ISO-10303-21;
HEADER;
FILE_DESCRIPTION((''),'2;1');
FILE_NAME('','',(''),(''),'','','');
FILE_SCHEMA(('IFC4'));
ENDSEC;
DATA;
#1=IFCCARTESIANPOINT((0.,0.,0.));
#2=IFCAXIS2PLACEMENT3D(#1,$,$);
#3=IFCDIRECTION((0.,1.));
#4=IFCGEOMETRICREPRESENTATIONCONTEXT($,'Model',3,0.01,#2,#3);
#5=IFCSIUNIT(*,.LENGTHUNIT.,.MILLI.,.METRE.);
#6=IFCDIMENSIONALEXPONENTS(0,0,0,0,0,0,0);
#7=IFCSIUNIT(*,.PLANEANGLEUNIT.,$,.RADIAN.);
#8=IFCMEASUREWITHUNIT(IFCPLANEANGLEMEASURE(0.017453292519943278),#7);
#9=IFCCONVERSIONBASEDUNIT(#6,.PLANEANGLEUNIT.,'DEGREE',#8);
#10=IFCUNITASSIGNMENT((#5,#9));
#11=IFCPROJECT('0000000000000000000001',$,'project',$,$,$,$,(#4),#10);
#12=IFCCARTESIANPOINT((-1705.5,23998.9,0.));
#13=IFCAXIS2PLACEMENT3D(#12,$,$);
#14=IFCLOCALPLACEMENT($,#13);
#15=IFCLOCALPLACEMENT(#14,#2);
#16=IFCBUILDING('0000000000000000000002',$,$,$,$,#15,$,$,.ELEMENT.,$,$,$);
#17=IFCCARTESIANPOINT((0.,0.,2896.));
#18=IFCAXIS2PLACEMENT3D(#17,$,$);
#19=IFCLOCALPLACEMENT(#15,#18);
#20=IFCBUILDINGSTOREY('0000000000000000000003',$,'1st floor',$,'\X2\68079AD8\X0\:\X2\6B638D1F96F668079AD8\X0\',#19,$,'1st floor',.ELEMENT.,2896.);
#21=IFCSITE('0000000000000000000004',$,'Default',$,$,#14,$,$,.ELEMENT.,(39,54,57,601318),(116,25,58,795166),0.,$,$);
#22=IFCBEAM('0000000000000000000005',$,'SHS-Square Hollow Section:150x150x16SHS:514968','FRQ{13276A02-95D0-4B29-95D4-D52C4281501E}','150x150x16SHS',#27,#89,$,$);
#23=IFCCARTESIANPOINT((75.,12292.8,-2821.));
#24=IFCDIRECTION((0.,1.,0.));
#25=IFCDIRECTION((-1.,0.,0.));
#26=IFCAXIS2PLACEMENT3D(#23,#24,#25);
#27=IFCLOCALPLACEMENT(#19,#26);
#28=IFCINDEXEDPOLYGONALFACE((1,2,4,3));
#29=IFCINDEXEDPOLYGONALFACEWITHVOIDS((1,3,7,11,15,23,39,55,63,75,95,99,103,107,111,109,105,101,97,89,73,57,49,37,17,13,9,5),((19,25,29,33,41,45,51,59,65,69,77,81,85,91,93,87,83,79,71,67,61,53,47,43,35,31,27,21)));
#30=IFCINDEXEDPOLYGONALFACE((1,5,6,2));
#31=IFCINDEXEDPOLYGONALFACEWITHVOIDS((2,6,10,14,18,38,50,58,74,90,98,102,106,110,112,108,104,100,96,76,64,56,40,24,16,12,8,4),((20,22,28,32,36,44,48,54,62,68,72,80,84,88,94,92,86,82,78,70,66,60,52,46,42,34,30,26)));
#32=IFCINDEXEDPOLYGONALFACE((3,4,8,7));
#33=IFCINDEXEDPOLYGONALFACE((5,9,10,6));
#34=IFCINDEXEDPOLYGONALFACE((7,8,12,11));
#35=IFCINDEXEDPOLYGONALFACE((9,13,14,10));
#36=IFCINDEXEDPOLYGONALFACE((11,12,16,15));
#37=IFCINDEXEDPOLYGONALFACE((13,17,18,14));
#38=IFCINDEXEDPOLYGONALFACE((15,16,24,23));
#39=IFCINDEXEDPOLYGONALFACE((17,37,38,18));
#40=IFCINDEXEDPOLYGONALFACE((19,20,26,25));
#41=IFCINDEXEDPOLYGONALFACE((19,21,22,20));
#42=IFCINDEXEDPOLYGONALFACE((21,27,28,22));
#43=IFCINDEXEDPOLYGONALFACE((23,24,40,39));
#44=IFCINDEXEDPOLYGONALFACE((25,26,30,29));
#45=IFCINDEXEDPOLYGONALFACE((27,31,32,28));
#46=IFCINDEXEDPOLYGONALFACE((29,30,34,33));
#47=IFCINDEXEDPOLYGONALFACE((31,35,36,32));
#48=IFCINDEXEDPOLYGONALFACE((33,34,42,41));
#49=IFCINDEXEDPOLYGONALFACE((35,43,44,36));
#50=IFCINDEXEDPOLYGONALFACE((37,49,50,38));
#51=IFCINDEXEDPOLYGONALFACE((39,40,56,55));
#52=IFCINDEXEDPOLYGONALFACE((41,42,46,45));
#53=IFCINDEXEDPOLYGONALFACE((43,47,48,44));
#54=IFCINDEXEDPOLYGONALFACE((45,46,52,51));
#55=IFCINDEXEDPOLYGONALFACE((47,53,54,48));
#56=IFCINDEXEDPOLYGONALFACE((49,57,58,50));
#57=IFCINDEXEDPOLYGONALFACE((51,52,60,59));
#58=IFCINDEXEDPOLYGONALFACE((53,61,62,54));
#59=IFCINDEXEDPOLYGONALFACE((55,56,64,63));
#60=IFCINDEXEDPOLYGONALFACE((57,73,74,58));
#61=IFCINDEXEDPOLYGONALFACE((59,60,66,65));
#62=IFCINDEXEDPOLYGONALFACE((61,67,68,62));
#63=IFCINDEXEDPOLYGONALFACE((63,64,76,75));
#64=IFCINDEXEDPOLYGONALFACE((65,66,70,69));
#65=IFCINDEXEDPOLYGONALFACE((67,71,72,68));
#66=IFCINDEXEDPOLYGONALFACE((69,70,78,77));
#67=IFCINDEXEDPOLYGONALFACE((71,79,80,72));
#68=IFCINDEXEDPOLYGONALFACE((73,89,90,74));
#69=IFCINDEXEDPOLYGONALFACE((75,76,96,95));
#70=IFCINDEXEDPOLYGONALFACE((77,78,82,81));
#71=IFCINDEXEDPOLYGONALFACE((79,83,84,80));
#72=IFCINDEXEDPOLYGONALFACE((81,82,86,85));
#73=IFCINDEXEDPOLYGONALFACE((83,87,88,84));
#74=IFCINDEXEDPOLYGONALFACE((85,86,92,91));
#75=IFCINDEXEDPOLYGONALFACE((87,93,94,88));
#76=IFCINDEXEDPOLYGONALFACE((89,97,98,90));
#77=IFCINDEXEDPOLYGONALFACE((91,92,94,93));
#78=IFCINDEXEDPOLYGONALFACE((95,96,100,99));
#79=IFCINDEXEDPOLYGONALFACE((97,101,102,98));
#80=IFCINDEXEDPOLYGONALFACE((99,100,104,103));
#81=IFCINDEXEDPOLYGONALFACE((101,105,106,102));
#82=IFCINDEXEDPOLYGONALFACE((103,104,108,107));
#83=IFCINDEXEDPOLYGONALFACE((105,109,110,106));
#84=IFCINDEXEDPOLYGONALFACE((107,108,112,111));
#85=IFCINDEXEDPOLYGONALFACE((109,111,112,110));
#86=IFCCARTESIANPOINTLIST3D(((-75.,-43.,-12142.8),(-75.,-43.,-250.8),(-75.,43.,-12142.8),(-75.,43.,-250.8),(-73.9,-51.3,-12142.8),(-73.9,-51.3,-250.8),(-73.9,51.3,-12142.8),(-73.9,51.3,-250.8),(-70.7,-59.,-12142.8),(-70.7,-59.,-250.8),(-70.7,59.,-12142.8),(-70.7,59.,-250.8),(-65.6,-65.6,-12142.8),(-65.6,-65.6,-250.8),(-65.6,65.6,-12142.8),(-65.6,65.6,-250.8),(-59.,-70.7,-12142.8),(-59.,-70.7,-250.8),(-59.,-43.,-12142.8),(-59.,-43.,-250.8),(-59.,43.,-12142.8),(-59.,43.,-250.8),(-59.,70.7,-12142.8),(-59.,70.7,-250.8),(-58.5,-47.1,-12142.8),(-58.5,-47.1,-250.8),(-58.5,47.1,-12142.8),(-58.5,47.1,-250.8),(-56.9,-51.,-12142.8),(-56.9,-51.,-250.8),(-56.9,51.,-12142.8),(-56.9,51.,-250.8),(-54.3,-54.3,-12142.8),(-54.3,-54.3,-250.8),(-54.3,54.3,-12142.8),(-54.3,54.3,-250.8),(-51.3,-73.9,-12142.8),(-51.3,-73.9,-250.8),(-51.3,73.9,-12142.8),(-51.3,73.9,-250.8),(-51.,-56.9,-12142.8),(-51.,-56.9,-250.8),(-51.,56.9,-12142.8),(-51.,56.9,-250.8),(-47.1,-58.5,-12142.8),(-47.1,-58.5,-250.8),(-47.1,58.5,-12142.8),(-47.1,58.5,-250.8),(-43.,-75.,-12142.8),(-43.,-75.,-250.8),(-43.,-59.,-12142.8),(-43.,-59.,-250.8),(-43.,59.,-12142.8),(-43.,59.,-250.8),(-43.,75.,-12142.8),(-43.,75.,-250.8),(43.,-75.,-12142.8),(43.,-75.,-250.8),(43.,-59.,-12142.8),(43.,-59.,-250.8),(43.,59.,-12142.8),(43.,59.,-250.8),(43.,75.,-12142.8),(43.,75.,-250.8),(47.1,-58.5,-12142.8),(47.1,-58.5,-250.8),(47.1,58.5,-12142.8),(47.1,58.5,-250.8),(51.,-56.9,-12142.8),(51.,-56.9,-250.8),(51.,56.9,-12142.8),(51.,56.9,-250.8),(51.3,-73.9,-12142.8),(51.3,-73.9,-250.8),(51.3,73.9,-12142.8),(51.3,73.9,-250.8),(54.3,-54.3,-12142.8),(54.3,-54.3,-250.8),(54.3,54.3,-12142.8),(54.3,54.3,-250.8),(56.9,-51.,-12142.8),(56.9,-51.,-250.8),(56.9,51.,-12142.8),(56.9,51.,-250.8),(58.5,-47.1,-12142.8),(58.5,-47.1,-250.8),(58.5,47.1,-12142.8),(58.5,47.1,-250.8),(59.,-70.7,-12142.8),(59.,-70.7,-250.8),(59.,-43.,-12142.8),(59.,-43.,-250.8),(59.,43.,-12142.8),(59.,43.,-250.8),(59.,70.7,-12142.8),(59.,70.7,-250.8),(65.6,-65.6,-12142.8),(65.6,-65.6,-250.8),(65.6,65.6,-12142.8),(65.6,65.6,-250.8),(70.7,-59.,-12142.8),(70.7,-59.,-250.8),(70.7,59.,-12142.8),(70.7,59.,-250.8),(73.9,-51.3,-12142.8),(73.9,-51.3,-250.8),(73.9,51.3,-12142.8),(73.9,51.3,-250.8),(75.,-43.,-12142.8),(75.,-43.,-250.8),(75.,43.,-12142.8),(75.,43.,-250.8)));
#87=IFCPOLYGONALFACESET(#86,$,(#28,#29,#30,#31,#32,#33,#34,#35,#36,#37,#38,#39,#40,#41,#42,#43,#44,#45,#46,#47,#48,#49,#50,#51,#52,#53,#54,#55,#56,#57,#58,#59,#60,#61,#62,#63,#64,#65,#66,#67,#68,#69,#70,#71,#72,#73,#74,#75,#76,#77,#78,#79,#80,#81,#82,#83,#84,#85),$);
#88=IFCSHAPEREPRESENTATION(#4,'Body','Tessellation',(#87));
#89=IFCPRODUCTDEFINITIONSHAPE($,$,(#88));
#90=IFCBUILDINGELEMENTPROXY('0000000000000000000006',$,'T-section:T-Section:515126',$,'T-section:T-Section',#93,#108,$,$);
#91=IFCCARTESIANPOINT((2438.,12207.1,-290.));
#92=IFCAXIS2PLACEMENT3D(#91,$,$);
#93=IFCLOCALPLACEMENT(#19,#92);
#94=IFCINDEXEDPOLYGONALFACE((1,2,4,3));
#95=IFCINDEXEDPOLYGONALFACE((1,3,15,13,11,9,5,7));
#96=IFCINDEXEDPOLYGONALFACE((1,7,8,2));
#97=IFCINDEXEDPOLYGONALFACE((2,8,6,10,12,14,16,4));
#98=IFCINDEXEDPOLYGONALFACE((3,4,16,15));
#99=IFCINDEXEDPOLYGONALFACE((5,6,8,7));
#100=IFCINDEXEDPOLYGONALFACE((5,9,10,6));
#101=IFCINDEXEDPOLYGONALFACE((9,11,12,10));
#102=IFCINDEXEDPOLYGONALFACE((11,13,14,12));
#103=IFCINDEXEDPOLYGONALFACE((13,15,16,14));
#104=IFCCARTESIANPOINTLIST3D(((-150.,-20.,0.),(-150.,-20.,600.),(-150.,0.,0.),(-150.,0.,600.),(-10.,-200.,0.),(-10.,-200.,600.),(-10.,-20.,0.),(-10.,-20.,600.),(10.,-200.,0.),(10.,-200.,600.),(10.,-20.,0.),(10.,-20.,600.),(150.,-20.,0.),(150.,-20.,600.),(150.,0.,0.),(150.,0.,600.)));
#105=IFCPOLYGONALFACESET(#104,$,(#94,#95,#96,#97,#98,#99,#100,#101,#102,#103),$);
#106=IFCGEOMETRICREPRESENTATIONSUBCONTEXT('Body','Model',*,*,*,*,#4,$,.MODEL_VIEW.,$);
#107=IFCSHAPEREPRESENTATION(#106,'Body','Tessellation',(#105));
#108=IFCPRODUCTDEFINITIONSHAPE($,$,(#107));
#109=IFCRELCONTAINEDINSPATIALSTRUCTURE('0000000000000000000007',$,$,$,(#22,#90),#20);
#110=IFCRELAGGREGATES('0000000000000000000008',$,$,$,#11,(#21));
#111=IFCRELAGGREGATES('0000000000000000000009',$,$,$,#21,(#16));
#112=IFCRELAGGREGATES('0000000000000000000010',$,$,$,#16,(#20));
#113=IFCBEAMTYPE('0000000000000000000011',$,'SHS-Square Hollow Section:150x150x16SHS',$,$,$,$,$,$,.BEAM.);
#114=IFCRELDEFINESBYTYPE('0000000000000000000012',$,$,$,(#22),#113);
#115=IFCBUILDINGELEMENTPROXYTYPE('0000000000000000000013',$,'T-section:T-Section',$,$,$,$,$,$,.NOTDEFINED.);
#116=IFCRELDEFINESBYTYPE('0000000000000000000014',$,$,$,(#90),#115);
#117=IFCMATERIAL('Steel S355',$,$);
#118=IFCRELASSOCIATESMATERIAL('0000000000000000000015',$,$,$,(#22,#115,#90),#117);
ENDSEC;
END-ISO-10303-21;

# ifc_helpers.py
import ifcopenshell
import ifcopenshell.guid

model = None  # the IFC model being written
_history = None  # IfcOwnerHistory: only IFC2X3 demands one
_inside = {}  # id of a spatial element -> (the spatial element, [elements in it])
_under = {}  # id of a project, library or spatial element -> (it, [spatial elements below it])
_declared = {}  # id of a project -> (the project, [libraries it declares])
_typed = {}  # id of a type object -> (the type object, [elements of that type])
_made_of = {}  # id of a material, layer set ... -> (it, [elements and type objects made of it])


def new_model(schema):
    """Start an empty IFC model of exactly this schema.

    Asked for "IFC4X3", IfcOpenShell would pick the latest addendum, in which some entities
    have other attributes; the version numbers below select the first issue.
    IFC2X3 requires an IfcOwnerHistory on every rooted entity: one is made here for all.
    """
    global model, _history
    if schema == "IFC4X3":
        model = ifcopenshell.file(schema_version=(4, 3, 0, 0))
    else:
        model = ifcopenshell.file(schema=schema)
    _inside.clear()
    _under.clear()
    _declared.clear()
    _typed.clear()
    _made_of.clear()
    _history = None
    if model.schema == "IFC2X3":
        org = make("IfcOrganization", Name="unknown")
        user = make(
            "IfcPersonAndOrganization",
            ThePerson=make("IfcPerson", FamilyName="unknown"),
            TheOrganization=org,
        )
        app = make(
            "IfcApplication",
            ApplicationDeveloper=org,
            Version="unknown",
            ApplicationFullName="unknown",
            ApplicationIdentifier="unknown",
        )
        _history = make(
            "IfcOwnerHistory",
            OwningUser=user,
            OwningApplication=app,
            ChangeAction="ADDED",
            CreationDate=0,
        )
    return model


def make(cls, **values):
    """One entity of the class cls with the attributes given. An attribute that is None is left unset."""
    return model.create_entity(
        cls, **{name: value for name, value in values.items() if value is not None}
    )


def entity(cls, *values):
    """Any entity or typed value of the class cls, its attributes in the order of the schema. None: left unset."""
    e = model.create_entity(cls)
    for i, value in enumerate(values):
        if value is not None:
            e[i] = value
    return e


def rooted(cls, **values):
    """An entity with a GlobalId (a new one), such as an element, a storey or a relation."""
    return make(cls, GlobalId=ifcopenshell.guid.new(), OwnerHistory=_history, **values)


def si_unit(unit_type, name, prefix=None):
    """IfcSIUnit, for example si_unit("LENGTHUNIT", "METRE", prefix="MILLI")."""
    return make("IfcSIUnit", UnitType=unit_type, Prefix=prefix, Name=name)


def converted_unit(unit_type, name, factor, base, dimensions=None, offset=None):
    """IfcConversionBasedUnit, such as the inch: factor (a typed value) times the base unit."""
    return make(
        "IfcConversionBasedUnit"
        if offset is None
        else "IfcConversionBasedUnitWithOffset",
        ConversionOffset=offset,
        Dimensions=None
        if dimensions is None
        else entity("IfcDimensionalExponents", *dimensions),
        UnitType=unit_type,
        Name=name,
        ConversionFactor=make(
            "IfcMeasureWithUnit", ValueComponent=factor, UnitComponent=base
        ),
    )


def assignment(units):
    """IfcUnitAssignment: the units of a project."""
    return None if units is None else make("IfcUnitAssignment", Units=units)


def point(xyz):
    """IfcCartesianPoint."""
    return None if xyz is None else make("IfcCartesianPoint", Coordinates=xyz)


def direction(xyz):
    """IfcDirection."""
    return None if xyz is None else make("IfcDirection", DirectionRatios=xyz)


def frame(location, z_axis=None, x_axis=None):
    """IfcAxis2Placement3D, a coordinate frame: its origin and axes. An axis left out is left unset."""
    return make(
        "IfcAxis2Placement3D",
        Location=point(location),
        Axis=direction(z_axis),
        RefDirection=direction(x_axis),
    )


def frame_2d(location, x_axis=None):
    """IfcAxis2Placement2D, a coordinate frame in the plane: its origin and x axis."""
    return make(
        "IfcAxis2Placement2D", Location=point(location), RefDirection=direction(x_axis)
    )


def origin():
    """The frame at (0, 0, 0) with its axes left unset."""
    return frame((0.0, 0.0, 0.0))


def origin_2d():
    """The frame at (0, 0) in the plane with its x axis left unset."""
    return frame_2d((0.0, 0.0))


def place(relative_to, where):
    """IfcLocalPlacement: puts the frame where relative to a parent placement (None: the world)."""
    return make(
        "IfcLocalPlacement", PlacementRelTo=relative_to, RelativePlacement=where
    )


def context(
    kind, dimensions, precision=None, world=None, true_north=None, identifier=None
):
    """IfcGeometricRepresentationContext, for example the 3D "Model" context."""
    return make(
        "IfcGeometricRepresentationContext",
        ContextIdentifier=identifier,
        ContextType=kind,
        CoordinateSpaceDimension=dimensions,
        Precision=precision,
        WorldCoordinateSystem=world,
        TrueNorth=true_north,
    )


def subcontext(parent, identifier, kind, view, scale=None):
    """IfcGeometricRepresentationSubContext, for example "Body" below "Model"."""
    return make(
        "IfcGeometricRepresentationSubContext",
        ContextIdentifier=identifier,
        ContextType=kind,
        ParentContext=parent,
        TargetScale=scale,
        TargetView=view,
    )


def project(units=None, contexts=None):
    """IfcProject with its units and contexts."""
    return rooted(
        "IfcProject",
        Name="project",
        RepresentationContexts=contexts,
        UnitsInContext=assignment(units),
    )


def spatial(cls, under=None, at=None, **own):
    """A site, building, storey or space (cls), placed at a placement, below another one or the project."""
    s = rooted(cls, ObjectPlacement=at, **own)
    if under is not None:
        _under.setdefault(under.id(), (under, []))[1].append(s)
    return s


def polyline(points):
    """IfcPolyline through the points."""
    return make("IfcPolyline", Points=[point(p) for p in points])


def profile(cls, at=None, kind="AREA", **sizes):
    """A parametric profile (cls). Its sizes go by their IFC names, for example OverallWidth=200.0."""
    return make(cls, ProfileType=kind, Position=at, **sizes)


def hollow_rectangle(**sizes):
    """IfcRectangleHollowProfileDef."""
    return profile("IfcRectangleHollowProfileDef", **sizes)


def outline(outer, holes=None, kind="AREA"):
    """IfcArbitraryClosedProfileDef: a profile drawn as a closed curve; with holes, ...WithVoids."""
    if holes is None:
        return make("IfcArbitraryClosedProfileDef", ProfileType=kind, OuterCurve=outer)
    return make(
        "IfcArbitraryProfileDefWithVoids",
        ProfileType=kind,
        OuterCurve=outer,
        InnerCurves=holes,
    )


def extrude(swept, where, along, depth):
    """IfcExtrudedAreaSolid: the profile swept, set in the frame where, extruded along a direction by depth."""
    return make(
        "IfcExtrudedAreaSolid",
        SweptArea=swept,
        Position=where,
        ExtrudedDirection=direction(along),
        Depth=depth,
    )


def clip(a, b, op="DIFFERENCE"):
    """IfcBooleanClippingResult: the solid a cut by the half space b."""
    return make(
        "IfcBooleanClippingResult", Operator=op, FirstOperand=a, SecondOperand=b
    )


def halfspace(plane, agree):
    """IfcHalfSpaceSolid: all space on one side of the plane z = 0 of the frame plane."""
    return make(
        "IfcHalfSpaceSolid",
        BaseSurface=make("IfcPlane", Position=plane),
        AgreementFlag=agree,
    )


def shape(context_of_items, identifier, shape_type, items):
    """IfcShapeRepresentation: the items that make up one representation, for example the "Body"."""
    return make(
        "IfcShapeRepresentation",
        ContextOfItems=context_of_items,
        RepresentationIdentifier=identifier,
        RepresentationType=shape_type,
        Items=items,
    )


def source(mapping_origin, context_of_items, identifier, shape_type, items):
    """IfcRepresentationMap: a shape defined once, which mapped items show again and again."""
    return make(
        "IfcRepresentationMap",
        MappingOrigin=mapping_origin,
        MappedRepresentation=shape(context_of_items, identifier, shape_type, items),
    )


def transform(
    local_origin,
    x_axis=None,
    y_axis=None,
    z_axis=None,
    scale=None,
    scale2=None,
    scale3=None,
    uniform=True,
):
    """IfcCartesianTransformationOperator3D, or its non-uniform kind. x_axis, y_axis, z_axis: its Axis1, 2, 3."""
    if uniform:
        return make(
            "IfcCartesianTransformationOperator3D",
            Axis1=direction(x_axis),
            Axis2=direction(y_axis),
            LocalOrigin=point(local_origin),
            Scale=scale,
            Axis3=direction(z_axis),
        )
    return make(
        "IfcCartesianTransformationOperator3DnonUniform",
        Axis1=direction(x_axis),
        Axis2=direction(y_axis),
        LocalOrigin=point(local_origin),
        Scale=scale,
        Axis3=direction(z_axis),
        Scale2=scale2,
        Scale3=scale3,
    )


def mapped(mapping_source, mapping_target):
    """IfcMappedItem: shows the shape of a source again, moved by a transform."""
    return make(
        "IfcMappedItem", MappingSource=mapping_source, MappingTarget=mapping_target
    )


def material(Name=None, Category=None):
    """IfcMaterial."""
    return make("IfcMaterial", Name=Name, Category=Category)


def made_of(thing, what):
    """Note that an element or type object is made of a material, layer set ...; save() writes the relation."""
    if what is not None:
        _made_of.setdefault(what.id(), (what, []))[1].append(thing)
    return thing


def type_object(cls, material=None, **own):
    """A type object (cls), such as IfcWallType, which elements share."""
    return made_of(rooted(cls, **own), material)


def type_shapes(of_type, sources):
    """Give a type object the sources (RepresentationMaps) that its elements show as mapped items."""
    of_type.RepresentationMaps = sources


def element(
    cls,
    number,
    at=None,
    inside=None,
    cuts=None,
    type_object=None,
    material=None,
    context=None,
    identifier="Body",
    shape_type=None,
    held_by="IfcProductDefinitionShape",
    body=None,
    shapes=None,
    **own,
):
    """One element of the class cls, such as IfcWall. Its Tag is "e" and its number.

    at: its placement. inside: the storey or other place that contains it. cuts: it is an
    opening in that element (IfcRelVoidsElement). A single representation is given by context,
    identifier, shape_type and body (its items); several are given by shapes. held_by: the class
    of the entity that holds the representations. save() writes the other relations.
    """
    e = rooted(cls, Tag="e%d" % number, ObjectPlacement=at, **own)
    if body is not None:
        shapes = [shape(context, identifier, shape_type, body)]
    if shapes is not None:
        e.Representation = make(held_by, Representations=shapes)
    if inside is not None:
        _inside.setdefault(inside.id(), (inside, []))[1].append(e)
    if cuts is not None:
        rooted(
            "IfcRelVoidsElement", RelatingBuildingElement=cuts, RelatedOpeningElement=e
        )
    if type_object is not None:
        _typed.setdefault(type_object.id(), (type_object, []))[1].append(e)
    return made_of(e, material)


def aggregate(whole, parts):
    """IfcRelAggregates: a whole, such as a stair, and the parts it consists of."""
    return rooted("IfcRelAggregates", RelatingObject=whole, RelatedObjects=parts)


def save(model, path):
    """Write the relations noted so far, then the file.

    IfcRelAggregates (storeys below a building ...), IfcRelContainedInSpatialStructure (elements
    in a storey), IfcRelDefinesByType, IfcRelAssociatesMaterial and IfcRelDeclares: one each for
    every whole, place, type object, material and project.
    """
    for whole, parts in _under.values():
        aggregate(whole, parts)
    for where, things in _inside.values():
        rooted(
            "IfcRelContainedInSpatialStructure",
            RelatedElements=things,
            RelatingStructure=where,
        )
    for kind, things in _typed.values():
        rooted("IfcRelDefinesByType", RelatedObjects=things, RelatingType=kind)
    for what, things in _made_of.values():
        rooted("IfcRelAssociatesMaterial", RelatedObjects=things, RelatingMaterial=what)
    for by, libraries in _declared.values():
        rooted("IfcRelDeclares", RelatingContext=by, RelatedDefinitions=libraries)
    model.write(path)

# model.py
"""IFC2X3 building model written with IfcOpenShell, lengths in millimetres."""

from ifc_helpers import new_model, entity, si_unit, converted_unit, direction, frame, origin, origin_2d, place, context, subcontext, project, spatial, polyline, hollow_rectangle, outline, extrude, clip, halfspace, source, transform, mapped, material, type_object, type_shapes, element, save


model = new_model("IFC2X3")

# Units and contexts
model_context = context("Model", 3, precision=0.01, world=origin(), true_north=direction((0.0, 1.0)))
body_context = subcontext(model_context, "Body", "Model", "MODEL_VIEW")
ifc_project = project(units=[si_unit("LENGTHUNIT", "METRE", prefix="MILLI"), converted_unit("PLANEANGLEUNIT", "DEGREE", entity("IfcPlaneAngleMeasure", 0.017453292519943278), si_unit("PLANEANGLEUNIT", "RADIAN"), dimensions=[0, 0, 0, 0, 0, 0, 0])], contexts=[model_context])

# Site, building, storey
site_placement = place(None, frame((-1705.5, 23998.9, 0.0)))
site = spatial("IfcSite", under=ifc_project, at=site_placement, Name="Default", CompositionType="ELEMENT", RefLatitude=(39, 54, 57, 601318), RefLongitude=(116, 25, 58, 795166), RefElevation=0.0)
building_placement = place(site_placement, origin())
building = spatial("IfcBuilding", under=site, at=building_placement, CompositionType="ELEMENT")
storey_placement = place(building_placement, frame((0.0, 0.0, 2896.0)))
storey = spatial("IfcBuildingStorey", under=building, at=storey_placement, Name="1st floor", ObjectType="标高:正负零标高", LongName="1st floor", CompositionType="ELEMENT", Elevation=2896.0)

# Shared definitions
ifc_material_1 = material(Name="Steel S355")

# Shared definitions
beam_type_1 = type_object("IfcBeamType", Name="SHS-Square Hollow Section:150x150x16SHS", PredefinedType="BEAM")

# Beam
beam_1_placement = place(storey_placement, frame((75.0, 12292.8, -2821.0), z_axis=(0.0, 1.0, 0.0), x_axis=(-1.0, 0.0, 0.0)))
element("IfcBeam", 1, at=beam_1_placement, inside=storey, type_object=beam_type_1, material=ifc_material_1, Name="SHS-Square Hollow Section:150x150x16SHS:514968", Description="FRQ{13276A02-95D0-4B29-95D4-D52C4281501E}", ObjectType="150x150x16SHS", context=model_context, shape_type="Clipping", body=[
    clip(clip(extrude(hollow_rectangle(XDim=150.0, YDim=150.0, WallThickness=16.0, InnerFilletRadius=16.0, OuterFilletRadius=32.0, at=origin_2d()), origin(), (0.0, 0.0, -1.0), 12398.9), halfspace(frame((75.0, -75.0, -12142.8), z_axis=(0.0, 0.0, 1.0), x_axis=(1.0, 0.0, 0.0)), True)), halfspace(frame((75.0, -75.0, -250.8), z_axis=(0.0, 0.0, -1.0), x_axis=(-1.0, 0.0, 0.0)), True)),
])

# Building element proxy
building_element_proxy_type_1 = type_object("IfcBuildingElementProxyType", Name="T-section:T-Section", PredefinedType="NOTDEFINED", material=ifc_material_1)
shared_shape_1 = source(origin(), body_context, "Body", "SweptSolid", [
    extrude(outline(polyline([(-10.0, -140.0), (10.0, -140.0), (10.0, 40.0), (150.0, 40.0), (150.0, 60.0), (-150.0, 60.0), (-150.0, 40.0), (-10.0, 40.0), (-10.0, -140.0)])), frame((0.0, -60.0, 0.0)), (0.0, 0.0, 1.0), 600.0),
])
type_shapes(building_element_proxy_type_1, [shared_shape_1])
proxy_placement = place(storey_placement, frame((2438.0, 12207.1, -290.0)))
element("IfcBuildingElementProxy", 2, at=proxy_placement, inside=storey, type_object=building_element_proxy_type_1, material=ifc_material_1, Name="T-section:T-Section:515126", ObjectType="T-section:T-Section", context=body_context, shape_type="MappedRepresentation", body=[
    mapped(shared_shape_1, transform((0.0, 0.0, 0.0), scale=1.0)),
])

save(model, "model.ifc")
